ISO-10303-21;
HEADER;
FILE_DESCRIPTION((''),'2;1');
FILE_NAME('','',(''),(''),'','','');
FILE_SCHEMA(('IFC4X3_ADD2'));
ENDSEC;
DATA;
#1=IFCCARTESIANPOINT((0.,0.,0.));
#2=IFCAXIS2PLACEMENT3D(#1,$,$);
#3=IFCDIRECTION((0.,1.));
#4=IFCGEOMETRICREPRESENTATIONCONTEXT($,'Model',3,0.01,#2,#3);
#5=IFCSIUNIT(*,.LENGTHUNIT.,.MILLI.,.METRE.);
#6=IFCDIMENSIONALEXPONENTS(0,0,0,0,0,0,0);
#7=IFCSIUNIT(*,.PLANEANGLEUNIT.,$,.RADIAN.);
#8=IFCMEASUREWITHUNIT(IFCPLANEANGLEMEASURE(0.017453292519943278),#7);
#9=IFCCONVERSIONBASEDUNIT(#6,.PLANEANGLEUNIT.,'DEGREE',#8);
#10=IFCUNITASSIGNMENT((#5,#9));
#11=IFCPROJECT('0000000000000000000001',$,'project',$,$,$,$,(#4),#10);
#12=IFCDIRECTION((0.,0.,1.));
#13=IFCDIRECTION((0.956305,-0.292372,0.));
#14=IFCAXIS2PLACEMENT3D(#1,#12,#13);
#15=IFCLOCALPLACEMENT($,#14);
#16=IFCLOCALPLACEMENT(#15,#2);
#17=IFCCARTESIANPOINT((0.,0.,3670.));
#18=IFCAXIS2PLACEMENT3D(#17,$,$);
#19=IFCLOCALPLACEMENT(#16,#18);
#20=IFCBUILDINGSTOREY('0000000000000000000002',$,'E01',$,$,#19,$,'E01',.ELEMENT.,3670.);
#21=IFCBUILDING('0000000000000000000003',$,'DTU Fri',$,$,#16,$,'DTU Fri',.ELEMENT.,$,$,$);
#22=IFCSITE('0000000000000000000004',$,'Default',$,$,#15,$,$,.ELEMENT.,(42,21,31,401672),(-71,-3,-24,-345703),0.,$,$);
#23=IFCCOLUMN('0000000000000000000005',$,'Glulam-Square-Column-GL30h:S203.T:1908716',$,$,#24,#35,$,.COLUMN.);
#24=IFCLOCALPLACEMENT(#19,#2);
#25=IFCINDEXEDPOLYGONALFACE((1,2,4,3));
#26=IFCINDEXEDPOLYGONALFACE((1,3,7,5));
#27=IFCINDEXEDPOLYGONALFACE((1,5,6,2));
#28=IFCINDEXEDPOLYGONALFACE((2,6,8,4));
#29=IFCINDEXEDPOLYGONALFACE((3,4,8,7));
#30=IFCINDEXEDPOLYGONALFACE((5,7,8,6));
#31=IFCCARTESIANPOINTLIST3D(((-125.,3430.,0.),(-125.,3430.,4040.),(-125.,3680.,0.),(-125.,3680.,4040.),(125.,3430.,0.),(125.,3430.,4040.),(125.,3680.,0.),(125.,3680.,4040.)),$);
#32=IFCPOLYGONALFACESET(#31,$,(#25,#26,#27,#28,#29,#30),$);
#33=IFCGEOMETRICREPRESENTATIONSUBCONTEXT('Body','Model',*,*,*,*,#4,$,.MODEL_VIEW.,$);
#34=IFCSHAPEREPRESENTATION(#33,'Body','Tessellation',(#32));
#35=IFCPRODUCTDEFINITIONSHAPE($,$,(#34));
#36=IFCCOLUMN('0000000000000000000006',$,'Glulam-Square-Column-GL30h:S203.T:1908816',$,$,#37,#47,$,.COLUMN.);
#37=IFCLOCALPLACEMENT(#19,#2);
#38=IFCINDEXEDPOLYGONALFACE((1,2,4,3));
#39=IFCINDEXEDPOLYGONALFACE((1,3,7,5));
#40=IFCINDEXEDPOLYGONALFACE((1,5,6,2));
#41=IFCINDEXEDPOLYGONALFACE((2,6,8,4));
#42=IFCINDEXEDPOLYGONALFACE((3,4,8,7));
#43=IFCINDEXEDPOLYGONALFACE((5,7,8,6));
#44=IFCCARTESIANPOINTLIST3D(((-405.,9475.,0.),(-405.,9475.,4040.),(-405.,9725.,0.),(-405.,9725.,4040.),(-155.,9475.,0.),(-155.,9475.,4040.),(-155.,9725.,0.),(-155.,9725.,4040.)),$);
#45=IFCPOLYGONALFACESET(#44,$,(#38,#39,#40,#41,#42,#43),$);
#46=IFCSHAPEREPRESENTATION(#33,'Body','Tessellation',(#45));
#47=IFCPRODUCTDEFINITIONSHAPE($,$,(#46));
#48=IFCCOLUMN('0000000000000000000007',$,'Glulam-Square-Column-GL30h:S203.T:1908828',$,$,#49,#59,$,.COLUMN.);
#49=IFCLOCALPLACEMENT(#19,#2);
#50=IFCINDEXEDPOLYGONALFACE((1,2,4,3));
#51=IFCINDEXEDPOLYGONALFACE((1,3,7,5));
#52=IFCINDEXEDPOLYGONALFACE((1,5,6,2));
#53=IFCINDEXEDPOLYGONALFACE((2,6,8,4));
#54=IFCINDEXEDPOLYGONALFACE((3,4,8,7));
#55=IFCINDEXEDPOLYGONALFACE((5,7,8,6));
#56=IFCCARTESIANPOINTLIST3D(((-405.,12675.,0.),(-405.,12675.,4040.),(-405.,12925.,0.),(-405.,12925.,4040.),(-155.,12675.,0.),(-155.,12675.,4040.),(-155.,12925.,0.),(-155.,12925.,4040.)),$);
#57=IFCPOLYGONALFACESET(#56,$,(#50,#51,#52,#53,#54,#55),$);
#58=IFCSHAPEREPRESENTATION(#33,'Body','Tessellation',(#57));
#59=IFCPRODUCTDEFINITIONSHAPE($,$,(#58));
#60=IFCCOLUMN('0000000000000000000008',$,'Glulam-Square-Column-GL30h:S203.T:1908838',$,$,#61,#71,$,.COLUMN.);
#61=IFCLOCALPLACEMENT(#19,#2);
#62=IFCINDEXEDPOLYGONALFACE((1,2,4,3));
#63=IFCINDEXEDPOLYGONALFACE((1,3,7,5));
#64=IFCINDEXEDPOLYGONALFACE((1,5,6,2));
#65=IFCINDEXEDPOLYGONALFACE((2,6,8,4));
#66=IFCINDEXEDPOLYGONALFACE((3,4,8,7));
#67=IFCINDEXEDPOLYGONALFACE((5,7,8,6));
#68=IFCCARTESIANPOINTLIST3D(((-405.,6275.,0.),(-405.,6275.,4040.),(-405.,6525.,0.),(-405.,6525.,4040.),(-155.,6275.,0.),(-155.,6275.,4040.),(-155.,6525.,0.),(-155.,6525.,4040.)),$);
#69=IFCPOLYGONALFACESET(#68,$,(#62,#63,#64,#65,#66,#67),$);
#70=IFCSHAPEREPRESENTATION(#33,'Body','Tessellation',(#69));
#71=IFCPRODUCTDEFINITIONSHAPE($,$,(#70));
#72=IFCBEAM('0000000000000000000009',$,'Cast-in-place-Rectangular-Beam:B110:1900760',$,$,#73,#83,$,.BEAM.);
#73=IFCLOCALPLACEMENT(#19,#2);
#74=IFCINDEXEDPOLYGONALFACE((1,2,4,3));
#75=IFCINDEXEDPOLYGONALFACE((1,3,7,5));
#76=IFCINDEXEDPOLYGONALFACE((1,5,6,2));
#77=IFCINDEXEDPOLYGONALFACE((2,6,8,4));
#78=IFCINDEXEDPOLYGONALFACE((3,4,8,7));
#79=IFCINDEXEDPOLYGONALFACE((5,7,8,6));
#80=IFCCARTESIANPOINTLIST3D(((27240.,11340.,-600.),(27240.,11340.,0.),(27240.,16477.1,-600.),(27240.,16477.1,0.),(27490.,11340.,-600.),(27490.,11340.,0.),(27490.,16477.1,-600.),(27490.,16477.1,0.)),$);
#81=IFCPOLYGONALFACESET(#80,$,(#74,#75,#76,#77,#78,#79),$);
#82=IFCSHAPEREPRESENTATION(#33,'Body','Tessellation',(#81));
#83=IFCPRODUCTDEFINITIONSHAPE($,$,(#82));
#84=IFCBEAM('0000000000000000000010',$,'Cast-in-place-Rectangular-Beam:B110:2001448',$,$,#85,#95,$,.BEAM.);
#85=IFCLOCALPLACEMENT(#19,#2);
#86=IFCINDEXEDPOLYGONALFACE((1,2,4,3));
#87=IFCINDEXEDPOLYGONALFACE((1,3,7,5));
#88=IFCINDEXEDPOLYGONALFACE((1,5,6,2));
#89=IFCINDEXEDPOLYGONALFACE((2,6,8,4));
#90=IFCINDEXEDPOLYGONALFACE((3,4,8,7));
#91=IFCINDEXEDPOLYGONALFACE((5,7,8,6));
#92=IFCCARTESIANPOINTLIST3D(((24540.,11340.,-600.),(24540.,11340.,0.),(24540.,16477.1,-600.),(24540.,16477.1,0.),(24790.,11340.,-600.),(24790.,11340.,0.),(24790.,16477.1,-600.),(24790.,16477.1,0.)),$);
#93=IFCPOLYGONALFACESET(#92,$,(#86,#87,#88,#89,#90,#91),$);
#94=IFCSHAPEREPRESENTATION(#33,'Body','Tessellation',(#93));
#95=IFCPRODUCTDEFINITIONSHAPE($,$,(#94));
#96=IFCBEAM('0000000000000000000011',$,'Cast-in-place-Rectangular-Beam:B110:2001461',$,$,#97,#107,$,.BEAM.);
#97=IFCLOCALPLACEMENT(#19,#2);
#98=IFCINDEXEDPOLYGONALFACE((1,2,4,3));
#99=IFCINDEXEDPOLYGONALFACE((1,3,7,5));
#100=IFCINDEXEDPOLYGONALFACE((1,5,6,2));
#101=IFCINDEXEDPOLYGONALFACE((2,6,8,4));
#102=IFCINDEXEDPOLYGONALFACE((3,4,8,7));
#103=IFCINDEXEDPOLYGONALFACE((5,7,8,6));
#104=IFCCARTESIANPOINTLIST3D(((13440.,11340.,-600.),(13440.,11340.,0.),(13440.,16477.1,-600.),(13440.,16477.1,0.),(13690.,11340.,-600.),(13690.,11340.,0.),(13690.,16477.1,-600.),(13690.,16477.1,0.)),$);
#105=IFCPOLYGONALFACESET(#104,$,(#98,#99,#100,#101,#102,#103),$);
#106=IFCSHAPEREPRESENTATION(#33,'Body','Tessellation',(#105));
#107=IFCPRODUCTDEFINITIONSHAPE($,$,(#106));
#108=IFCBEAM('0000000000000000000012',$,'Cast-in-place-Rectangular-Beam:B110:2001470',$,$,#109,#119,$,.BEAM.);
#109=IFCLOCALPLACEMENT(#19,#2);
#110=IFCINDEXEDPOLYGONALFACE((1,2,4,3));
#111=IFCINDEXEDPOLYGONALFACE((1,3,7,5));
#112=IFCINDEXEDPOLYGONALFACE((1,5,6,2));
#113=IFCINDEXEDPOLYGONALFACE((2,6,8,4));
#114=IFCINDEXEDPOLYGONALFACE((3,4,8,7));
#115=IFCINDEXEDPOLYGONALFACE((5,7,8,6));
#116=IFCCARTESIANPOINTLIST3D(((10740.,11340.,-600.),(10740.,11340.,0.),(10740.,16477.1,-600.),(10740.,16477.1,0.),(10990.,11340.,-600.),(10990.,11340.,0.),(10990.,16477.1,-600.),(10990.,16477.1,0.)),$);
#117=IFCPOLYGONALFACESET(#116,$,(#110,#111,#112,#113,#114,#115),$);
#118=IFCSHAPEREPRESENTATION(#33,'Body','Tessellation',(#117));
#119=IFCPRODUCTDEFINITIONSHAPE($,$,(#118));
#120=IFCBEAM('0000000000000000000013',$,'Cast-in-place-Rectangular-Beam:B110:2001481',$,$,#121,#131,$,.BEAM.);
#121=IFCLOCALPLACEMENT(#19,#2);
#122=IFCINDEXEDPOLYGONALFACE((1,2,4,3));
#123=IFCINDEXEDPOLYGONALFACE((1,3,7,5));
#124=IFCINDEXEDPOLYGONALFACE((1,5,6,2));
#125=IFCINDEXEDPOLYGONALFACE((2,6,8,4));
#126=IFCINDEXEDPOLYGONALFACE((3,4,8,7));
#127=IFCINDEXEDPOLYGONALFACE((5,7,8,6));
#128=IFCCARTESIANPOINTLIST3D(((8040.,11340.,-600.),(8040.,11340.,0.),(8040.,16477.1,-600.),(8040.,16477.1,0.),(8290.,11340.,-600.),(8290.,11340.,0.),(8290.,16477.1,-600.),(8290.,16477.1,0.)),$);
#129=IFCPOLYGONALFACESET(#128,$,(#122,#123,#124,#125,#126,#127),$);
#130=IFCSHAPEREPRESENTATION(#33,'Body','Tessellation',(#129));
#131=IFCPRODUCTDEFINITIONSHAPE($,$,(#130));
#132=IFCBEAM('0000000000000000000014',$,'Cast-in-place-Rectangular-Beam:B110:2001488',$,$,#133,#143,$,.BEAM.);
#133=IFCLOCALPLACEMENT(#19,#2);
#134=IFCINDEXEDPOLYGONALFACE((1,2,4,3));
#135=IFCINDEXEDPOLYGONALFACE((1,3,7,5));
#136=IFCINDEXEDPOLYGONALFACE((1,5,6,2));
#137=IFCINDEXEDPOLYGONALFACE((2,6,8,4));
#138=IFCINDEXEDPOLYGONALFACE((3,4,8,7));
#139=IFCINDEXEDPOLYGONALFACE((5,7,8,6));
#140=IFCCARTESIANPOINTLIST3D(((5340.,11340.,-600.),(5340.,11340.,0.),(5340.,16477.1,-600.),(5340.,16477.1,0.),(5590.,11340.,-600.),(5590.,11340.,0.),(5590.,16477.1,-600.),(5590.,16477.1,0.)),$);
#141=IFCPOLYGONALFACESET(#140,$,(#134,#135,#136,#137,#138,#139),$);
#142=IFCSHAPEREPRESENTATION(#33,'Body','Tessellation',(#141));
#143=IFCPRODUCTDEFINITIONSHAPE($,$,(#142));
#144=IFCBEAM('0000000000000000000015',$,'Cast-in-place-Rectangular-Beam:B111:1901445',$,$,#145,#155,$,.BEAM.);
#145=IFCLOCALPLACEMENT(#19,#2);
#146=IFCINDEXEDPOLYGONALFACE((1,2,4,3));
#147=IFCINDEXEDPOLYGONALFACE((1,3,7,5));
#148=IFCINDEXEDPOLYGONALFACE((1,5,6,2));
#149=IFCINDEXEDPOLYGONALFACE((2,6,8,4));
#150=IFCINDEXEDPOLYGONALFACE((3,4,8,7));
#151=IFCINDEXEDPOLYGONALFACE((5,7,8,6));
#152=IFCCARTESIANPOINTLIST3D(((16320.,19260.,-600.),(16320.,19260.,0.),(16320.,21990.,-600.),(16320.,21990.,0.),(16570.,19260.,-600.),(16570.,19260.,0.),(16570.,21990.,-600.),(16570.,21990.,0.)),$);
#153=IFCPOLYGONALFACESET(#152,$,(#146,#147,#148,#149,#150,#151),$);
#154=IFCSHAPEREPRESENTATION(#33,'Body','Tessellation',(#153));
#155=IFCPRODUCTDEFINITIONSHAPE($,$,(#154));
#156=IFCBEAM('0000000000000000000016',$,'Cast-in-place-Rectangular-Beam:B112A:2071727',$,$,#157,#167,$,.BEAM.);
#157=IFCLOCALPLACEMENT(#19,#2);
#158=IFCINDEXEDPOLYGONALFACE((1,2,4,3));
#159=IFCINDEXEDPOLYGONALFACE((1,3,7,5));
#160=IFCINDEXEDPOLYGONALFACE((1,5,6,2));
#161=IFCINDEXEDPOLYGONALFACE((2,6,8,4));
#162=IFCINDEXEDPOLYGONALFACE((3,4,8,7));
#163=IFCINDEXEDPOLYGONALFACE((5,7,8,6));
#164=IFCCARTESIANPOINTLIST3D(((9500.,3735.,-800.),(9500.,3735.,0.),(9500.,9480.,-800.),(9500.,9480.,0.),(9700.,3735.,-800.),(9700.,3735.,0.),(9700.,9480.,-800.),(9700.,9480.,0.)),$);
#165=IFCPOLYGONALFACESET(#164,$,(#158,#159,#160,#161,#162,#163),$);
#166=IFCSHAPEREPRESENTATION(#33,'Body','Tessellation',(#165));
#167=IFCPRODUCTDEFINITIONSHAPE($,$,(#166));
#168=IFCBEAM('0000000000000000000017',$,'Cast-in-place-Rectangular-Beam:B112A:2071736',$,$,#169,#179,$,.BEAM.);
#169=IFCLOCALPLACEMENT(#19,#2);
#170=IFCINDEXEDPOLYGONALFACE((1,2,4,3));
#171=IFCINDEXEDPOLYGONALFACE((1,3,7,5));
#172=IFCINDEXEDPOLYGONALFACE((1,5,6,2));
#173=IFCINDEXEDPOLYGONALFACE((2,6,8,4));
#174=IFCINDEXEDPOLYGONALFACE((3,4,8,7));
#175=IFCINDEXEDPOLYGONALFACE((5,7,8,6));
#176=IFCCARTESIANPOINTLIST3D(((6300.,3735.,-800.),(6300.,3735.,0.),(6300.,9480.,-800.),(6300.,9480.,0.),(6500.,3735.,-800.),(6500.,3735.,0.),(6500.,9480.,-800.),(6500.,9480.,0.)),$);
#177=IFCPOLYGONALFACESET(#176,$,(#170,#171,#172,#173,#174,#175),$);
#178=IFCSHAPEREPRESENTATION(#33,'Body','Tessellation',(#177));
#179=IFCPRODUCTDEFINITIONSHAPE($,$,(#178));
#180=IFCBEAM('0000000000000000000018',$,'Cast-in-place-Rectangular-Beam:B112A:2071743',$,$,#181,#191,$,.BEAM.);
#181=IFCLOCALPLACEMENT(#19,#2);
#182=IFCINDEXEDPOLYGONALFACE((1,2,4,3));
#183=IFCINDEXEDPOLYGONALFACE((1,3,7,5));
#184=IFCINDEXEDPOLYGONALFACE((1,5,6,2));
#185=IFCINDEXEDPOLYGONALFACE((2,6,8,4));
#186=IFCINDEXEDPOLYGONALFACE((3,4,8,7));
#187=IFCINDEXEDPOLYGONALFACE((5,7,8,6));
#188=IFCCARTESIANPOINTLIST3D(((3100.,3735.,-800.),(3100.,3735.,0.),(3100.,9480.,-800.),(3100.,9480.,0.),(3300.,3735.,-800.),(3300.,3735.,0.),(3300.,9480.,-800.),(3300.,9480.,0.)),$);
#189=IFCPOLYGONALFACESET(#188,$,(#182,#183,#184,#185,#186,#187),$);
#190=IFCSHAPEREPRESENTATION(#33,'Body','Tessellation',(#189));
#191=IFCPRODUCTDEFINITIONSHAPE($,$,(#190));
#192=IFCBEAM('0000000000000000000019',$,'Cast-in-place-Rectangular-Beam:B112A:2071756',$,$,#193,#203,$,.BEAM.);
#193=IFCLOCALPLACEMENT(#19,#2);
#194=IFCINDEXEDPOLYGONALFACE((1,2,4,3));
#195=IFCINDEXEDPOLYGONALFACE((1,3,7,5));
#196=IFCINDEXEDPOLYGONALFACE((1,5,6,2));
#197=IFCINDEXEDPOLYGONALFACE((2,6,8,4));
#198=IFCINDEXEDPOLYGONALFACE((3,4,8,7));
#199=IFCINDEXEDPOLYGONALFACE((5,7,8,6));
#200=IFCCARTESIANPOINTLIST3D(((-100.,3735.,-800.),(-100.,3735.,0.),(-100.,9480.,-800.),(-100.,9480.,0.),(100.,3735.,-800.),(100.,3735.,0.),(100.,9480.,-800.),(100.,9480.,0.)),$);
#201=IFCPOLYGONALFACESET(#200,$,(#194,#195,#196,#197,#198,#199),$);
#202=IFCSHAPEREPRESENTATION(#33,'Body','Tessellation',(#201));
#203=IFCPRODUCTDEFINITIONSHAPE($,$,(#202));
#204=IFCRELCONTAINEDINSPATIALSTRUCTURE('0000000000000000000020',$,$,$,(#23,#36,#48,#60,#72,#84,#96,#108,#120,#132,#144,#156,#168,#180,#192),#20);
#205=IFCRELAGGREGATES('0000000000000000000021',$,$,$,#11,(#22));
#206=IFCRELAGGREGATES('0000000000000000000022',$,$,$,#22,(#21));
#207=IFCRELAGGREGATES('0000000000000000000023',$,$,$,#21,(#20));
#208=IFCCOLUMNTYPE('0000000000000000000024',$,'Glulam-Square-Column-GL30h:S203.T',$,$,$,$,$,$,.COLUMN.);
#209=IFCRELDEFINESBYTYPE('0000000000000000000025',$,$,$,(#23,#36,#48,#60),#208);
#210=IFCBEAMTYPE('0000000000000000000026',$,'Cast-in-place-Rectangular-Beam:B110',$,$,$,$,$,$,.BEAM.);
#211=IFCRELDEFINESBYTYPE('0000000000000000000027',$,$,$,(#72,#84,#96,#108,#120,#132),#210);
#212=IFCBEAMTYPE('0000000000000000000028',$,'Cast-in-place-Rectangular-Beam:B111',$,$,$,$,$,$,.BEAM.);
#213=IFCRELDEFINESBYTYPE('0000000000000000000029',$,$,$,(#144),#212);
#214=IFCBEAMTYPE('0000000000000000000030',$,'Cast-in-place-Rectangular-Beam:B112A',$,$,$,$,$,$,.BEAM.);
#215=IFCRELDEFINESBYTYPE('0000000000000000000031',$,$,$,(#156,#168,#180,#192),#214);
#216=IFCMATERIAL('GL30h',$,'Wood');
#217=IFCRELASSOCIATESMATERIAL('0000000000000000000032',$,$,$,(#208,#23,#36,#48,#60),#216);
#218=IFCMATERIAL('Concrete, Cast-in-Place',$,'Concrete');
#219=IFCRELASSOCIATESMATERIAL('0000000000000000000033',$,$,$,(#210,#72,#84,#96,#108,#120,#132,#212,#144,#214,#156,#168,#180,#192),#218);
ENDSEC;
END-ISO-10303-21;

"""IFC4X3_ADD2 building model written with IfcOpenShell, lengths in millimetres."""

from ifc_helpers import new_model, entity, si_unit, converted_unit, direction, frame, origin, origin_2d_with_axis, place, context, subcontext, project, spatial, rectangle, extrude, source, transform, mapped, material, material_profile, profile_set, profile_usage, type_object, type_shapes, element, save


model = new_model("IFC4X3_ADD2")

# Units and contexts
model_context = context("Model", 3, precision=0.01, world=origin(), true_north=direction((0.0, 1.0)))
body_context = subcontext(model_context, "Body", "Model", "MODEL_VIEW")
ifc_project = project(units=[si_unit("LENGTHUNIT", "METRE", prefix="MILLI"), converted_unit("PLANEANGLEUNIT", "DEGREE", entity("IfcPlaneAngleMeasure", 0.017453292519943278), si_unit("PLANEANGLEUNIT", "RADIAN"), dimensions=[0, 0, 0, 0, 0, 0, 0])], contexts=[model_context])

# Site, building, storey
site_placement = place(None, frame((0.0, 0.0, 0.0), z_axis=(0.0, 0.0, 1.0), x_axis=(0.956305, -0.292372, 0.0)))
site = spatial("IfcSite", under=ifc_project, at=site_placement, Name="Default", CompositionType="ELEMENT", RefLatitude=(42, 21, 31, 401672), RefLongitude=(-71, -3, -24, -345703), RefElevation=0.0)
building_placement = place(site_placement, origin())
building = spatial("IfcBuilding", under=site, at=building_placement, Name="DTU Fri", LongName="DTU Fri", CompositionType="ELEMENT")
storey_placement = place(building_placement, frame((0.0, 0.0, 3670.0)))
storey = spatial("IfcBuildingStorey", under=building, at=storey_placement, Name="E01", LongName="E01", CompositionType="ELEMENT", Elevation=3670.0)

# Columns
ifc_material_1 = material(Name="GL30h", Category="Wood")
ifc_material_profile_1 = material_profile(ifc_material_1, rectangle(XDim=250.0, YDim=250.0, at=origin_2d_with_axis()), Name="S203.T")
ifc_profile_set_1 = profile_set([ifc_material_profile_1], Name="S203.T")
ifc_profile_usage_1 = profile_usage(ifc_profile_set_1)
column_type = type_object("IfcColumnType", Name="Glulam-Square-Column-GL30h:S203.T", PredefinedType="COLUMN", material=ifc_profile_set_1)
shared_shape_1 = source(origin(), body_context, "Body", "SweptSolid", [
    extrude(rectangle(XDim=250.0, YDim=250.0, at=origin_2d_with_axis()), frame((0.0, 0.0, 3670.0), z_axis=(0.0, 0.0, 1.0), x_axis=(0.0, 1.0, 0.0)), (0.0, 0.0, 1.0), 4040.0),
])
type_shapes(column_type, [shared_shape_1])
for number, where, name in (
    (1, (0.0, 3555.0, -3670.0), "Glulam-Square-Column-GL30h:S203.T:1908716"),
    (2, (-280.0, 9600.0, -3670.0), "Glulam-Square-Column-GL30h:S203.T:1908816"),
    (3, (-280.0, 12800.0, -3670.0), "Glulam-Square-Column-GL30h:S203.T:1908828"),
    (4, (-280.0, 6400.0, -3670.0), "Glulam-Square-Column-GL30h:S203.T:1908838"),
):
    element("IfcColumn", number, at=place(storey_placement, frame(where)), inside=storey, type_object=column_type, material=ifc_profile_usage_1, Name=name, PredefinedType="COLUMN", context=body_context, shape_type="MappedRepresentation", body=[
        mapped(shared_shape_1, transform((0.0, 0.0, 0.0), scale=1.0)),
    ])

# Beams
ifc_material_2 = material(Name="Concrete, Cast-in-Place", Category="Concrete")
ifc_material_profile_2 = material_profile(ifc_material_2, rectangle(XDim=600.0, YDim=250.0, at=origin_2d_with_axis()), Name="B110")
ifc_profile_set_2 = profile_set([ifc_material_profile_2], Name="B110")
ifc_profile_usage_2 = profile_usage(ifc_profile_set_2, cardinal=8)
beam_type_1 = type_object("IfcBeamType", Name="Cast-in-place-Rectangular-Beam:B110", PredefinedType="BEAM", material=ifc_profile_set_2)
shared_shape_2 = source(origin(), body_context, "Body", "SweptSolid", [
    extrude(rectangle(XDim=600.0, YDim=250.0, at=origin_2d_with_axis()), frame((-2536.0, 0.0, 0.0), z_axis=(1.0, 0.0, 0.0), x_axis=(0.0, 0.0, -1.0)), (0.0, 0.0, 1.0), 5137.1),
])
type_shapes(beam_type_1, [shared_shape_2])
for number, where, z_axis, x_axis, name in (
    (5, (27365.0, 13941.0, -300.0), (0.0, 0.0, 1.0), (0.0, -1.0, 0.0), "Cast-in-place-Rectangular-Beam:B110:1900760"),
    (6, (24665.0, 13941.0, -300.0), (0.0, 0.0, 1.0), (0.0, -1.0, 0.0), "Cast-in-place-Rectangular-Beam:B110:2001448"),
    (7, (13565.0, 13941.0, -300.0), (0.0, 0.0, 1.0), (0.0, -1.0, 0.0), "Cast-in-place-Rectangular-Beam:B110:2001461"),
    (8, (10865.0, 13941.0, -300.0), (0.0, 0.0, 1.0), (0.0, -1.0, 0.0), "Cast-in-place-Rectangular-Beam:B110:2001470"),
    (9, (8165.0, 13941.0, -300.0), (0.0, 0.0, 1.0), (0.0, -1.0, 0.0), "Cast-in-place-Rectangular-Beam:B110:2001481"),
    (10, (5465.0, 13941.0, -300.0), (0.0, 0.0, 1.0), (0.0, -1.0, 0.0), "Cast-in-place-Rectangular-Beam:B110:2001488"),
):
    element("IfcBeam", number, at=place(storey_placement, frame(where, z_axis=z_axis, x_axis=x_axis)), inside=storey, type_object=beam_type_1, material=ifc_profile_usage_2, Name=name, PredefinedType="BEAM", context=body_context, shape_type="MappedRepresentation", body=[
        mapped(shared_shape_2, transform((0.0, 0.0, 0.0), scale=1.0)),
    ])
ifc_material_profile_3 = material_profile(ifc_material_2, rectangle(XDim=600.0, YDim=250.0, at=origin_2d_with_axis()), Name="B111")
ifc_profile_set_3 = profile_set([ifc_material_profile_3], Name="B111")
ifc_profile_usage_3 = profile_usage(ifc_profile_set_3, cardinal=8)
beam_type_2 = type_object("IfcBeamType", Name="Cast-in-place-Rectangular-Beam:B111", PredefinedType="BEAM", material=ifc_profile_set_3)
shared_shape_3 = source(origin(), body_context, "Body", "SweptSolid", [
    extrude(rectangle(XDim=600.0, YDim=250.0, at=origin_2d_with_axis()), frame((-4676.3, 0.0, 0.0), z_axis=(1.0, 0.0, 0.0), x_axis=(0.0, 0.0, -1.0)), (0.0, 0.0, 1.0), 2730.0),
])
type_shapes(beam_type_2, [shared_shape_3])
beam_1_placement = place(storey_placement, frame((16445.0, 17313.7, -300.0), z_axis=(0.0, 0.0, 1.0), x_axis=(0.0, -1.0, 0.0)))
element("IfcBeam", 11, at=beam_1_placement, inside=storey, type_object=beam_type_2, material=ifc_profile_usage_3, Name="Cast-in-place-Rectangular-Beam:B111:1901445", PredefinedType="BEAM", context=body_context, shape_type="MappedRepresentation", body=[
    mapped(shared_shape_3, transform((0.0, 0.0, 0.0), scale=1.0)),
])
ifc_material_profile_4 = material_profile(ifc_material_2, rectangle(XDim=800.0, YDim=200.0, at=origin_2d_with_axis()), Name="B112A")
ifc_profile_set_4 = profile_set([ifc_material_profile_4], Name="B112A")
ifc_profile_usage_4 = profile_usage(ifc_profile_set_4, cardinal=8)
beam_type_3 = type_object("IfcBeamType", Name="Cast-in-place-Rectangular-Beam:B112A", PredefinedType="BEAM", material=ifc_profile_set_4)
shared_shape_4 = source(origin(), body_context, "Body", "SweptSolid", [
    extrude(rectangle(XDim=800.0, YDim=200.0, at=origin_2d_with_axis()), frame((-2895.0, 0.0, 0.0), z_axis=(1.0, 0.0, 0.0), x_axis=(0.0, 0.0, -1.0)), (0.0, 0.0, 1.0), 5745.0),
])
type_shapes(beam_type_3, [shared_shape_4])
for number, where, z_axis, x_axis, name in (
    (12, (9600.0, 6585.0, -400.0), (0.0, 0.0, 1.0), (0.0, -1.0, 0.0), "Cast-in-place-Rectangular-Beam:B112A:2071727"),
    (13, (6400.0, 6585.0, -400.0), (0.0, 0.0, 1.0), (0.0, -1.0, 0.0), "Cast-in-place-Rectangular-Beam:B112A:2071736"),
    (14, (3200.0, 6585.0, -400.0), (0.0, 0.0, 1.0), (0.0, -1.0, 0.0), "Cast-in-place-Rectangular-Beam:B112A:2071743"),
    (15, (0.0, 6585.0, -400.0), (0.0, 0.0, 1.0), (0.0, -1.0, 0.0), "Cast-in-place-Rectangular-Beam:B112A:2071756"),
):
    element("IfcBeam", number, at=place(storey_placement, frame(where, z_axis=z_axis, x_axis=x_axis)), inside=storey, type_object=beam_type_3, material=ifc_profile_usage_4, Name=name, PredefinedType="BEAM", context=body_context, shape_type="MappedRepresentation", body=[
        mapped(shared_shape_4, transform((0.0, 0.0, 0.0), scale=1.0)),
    ])

save(model, "model.ifc")
